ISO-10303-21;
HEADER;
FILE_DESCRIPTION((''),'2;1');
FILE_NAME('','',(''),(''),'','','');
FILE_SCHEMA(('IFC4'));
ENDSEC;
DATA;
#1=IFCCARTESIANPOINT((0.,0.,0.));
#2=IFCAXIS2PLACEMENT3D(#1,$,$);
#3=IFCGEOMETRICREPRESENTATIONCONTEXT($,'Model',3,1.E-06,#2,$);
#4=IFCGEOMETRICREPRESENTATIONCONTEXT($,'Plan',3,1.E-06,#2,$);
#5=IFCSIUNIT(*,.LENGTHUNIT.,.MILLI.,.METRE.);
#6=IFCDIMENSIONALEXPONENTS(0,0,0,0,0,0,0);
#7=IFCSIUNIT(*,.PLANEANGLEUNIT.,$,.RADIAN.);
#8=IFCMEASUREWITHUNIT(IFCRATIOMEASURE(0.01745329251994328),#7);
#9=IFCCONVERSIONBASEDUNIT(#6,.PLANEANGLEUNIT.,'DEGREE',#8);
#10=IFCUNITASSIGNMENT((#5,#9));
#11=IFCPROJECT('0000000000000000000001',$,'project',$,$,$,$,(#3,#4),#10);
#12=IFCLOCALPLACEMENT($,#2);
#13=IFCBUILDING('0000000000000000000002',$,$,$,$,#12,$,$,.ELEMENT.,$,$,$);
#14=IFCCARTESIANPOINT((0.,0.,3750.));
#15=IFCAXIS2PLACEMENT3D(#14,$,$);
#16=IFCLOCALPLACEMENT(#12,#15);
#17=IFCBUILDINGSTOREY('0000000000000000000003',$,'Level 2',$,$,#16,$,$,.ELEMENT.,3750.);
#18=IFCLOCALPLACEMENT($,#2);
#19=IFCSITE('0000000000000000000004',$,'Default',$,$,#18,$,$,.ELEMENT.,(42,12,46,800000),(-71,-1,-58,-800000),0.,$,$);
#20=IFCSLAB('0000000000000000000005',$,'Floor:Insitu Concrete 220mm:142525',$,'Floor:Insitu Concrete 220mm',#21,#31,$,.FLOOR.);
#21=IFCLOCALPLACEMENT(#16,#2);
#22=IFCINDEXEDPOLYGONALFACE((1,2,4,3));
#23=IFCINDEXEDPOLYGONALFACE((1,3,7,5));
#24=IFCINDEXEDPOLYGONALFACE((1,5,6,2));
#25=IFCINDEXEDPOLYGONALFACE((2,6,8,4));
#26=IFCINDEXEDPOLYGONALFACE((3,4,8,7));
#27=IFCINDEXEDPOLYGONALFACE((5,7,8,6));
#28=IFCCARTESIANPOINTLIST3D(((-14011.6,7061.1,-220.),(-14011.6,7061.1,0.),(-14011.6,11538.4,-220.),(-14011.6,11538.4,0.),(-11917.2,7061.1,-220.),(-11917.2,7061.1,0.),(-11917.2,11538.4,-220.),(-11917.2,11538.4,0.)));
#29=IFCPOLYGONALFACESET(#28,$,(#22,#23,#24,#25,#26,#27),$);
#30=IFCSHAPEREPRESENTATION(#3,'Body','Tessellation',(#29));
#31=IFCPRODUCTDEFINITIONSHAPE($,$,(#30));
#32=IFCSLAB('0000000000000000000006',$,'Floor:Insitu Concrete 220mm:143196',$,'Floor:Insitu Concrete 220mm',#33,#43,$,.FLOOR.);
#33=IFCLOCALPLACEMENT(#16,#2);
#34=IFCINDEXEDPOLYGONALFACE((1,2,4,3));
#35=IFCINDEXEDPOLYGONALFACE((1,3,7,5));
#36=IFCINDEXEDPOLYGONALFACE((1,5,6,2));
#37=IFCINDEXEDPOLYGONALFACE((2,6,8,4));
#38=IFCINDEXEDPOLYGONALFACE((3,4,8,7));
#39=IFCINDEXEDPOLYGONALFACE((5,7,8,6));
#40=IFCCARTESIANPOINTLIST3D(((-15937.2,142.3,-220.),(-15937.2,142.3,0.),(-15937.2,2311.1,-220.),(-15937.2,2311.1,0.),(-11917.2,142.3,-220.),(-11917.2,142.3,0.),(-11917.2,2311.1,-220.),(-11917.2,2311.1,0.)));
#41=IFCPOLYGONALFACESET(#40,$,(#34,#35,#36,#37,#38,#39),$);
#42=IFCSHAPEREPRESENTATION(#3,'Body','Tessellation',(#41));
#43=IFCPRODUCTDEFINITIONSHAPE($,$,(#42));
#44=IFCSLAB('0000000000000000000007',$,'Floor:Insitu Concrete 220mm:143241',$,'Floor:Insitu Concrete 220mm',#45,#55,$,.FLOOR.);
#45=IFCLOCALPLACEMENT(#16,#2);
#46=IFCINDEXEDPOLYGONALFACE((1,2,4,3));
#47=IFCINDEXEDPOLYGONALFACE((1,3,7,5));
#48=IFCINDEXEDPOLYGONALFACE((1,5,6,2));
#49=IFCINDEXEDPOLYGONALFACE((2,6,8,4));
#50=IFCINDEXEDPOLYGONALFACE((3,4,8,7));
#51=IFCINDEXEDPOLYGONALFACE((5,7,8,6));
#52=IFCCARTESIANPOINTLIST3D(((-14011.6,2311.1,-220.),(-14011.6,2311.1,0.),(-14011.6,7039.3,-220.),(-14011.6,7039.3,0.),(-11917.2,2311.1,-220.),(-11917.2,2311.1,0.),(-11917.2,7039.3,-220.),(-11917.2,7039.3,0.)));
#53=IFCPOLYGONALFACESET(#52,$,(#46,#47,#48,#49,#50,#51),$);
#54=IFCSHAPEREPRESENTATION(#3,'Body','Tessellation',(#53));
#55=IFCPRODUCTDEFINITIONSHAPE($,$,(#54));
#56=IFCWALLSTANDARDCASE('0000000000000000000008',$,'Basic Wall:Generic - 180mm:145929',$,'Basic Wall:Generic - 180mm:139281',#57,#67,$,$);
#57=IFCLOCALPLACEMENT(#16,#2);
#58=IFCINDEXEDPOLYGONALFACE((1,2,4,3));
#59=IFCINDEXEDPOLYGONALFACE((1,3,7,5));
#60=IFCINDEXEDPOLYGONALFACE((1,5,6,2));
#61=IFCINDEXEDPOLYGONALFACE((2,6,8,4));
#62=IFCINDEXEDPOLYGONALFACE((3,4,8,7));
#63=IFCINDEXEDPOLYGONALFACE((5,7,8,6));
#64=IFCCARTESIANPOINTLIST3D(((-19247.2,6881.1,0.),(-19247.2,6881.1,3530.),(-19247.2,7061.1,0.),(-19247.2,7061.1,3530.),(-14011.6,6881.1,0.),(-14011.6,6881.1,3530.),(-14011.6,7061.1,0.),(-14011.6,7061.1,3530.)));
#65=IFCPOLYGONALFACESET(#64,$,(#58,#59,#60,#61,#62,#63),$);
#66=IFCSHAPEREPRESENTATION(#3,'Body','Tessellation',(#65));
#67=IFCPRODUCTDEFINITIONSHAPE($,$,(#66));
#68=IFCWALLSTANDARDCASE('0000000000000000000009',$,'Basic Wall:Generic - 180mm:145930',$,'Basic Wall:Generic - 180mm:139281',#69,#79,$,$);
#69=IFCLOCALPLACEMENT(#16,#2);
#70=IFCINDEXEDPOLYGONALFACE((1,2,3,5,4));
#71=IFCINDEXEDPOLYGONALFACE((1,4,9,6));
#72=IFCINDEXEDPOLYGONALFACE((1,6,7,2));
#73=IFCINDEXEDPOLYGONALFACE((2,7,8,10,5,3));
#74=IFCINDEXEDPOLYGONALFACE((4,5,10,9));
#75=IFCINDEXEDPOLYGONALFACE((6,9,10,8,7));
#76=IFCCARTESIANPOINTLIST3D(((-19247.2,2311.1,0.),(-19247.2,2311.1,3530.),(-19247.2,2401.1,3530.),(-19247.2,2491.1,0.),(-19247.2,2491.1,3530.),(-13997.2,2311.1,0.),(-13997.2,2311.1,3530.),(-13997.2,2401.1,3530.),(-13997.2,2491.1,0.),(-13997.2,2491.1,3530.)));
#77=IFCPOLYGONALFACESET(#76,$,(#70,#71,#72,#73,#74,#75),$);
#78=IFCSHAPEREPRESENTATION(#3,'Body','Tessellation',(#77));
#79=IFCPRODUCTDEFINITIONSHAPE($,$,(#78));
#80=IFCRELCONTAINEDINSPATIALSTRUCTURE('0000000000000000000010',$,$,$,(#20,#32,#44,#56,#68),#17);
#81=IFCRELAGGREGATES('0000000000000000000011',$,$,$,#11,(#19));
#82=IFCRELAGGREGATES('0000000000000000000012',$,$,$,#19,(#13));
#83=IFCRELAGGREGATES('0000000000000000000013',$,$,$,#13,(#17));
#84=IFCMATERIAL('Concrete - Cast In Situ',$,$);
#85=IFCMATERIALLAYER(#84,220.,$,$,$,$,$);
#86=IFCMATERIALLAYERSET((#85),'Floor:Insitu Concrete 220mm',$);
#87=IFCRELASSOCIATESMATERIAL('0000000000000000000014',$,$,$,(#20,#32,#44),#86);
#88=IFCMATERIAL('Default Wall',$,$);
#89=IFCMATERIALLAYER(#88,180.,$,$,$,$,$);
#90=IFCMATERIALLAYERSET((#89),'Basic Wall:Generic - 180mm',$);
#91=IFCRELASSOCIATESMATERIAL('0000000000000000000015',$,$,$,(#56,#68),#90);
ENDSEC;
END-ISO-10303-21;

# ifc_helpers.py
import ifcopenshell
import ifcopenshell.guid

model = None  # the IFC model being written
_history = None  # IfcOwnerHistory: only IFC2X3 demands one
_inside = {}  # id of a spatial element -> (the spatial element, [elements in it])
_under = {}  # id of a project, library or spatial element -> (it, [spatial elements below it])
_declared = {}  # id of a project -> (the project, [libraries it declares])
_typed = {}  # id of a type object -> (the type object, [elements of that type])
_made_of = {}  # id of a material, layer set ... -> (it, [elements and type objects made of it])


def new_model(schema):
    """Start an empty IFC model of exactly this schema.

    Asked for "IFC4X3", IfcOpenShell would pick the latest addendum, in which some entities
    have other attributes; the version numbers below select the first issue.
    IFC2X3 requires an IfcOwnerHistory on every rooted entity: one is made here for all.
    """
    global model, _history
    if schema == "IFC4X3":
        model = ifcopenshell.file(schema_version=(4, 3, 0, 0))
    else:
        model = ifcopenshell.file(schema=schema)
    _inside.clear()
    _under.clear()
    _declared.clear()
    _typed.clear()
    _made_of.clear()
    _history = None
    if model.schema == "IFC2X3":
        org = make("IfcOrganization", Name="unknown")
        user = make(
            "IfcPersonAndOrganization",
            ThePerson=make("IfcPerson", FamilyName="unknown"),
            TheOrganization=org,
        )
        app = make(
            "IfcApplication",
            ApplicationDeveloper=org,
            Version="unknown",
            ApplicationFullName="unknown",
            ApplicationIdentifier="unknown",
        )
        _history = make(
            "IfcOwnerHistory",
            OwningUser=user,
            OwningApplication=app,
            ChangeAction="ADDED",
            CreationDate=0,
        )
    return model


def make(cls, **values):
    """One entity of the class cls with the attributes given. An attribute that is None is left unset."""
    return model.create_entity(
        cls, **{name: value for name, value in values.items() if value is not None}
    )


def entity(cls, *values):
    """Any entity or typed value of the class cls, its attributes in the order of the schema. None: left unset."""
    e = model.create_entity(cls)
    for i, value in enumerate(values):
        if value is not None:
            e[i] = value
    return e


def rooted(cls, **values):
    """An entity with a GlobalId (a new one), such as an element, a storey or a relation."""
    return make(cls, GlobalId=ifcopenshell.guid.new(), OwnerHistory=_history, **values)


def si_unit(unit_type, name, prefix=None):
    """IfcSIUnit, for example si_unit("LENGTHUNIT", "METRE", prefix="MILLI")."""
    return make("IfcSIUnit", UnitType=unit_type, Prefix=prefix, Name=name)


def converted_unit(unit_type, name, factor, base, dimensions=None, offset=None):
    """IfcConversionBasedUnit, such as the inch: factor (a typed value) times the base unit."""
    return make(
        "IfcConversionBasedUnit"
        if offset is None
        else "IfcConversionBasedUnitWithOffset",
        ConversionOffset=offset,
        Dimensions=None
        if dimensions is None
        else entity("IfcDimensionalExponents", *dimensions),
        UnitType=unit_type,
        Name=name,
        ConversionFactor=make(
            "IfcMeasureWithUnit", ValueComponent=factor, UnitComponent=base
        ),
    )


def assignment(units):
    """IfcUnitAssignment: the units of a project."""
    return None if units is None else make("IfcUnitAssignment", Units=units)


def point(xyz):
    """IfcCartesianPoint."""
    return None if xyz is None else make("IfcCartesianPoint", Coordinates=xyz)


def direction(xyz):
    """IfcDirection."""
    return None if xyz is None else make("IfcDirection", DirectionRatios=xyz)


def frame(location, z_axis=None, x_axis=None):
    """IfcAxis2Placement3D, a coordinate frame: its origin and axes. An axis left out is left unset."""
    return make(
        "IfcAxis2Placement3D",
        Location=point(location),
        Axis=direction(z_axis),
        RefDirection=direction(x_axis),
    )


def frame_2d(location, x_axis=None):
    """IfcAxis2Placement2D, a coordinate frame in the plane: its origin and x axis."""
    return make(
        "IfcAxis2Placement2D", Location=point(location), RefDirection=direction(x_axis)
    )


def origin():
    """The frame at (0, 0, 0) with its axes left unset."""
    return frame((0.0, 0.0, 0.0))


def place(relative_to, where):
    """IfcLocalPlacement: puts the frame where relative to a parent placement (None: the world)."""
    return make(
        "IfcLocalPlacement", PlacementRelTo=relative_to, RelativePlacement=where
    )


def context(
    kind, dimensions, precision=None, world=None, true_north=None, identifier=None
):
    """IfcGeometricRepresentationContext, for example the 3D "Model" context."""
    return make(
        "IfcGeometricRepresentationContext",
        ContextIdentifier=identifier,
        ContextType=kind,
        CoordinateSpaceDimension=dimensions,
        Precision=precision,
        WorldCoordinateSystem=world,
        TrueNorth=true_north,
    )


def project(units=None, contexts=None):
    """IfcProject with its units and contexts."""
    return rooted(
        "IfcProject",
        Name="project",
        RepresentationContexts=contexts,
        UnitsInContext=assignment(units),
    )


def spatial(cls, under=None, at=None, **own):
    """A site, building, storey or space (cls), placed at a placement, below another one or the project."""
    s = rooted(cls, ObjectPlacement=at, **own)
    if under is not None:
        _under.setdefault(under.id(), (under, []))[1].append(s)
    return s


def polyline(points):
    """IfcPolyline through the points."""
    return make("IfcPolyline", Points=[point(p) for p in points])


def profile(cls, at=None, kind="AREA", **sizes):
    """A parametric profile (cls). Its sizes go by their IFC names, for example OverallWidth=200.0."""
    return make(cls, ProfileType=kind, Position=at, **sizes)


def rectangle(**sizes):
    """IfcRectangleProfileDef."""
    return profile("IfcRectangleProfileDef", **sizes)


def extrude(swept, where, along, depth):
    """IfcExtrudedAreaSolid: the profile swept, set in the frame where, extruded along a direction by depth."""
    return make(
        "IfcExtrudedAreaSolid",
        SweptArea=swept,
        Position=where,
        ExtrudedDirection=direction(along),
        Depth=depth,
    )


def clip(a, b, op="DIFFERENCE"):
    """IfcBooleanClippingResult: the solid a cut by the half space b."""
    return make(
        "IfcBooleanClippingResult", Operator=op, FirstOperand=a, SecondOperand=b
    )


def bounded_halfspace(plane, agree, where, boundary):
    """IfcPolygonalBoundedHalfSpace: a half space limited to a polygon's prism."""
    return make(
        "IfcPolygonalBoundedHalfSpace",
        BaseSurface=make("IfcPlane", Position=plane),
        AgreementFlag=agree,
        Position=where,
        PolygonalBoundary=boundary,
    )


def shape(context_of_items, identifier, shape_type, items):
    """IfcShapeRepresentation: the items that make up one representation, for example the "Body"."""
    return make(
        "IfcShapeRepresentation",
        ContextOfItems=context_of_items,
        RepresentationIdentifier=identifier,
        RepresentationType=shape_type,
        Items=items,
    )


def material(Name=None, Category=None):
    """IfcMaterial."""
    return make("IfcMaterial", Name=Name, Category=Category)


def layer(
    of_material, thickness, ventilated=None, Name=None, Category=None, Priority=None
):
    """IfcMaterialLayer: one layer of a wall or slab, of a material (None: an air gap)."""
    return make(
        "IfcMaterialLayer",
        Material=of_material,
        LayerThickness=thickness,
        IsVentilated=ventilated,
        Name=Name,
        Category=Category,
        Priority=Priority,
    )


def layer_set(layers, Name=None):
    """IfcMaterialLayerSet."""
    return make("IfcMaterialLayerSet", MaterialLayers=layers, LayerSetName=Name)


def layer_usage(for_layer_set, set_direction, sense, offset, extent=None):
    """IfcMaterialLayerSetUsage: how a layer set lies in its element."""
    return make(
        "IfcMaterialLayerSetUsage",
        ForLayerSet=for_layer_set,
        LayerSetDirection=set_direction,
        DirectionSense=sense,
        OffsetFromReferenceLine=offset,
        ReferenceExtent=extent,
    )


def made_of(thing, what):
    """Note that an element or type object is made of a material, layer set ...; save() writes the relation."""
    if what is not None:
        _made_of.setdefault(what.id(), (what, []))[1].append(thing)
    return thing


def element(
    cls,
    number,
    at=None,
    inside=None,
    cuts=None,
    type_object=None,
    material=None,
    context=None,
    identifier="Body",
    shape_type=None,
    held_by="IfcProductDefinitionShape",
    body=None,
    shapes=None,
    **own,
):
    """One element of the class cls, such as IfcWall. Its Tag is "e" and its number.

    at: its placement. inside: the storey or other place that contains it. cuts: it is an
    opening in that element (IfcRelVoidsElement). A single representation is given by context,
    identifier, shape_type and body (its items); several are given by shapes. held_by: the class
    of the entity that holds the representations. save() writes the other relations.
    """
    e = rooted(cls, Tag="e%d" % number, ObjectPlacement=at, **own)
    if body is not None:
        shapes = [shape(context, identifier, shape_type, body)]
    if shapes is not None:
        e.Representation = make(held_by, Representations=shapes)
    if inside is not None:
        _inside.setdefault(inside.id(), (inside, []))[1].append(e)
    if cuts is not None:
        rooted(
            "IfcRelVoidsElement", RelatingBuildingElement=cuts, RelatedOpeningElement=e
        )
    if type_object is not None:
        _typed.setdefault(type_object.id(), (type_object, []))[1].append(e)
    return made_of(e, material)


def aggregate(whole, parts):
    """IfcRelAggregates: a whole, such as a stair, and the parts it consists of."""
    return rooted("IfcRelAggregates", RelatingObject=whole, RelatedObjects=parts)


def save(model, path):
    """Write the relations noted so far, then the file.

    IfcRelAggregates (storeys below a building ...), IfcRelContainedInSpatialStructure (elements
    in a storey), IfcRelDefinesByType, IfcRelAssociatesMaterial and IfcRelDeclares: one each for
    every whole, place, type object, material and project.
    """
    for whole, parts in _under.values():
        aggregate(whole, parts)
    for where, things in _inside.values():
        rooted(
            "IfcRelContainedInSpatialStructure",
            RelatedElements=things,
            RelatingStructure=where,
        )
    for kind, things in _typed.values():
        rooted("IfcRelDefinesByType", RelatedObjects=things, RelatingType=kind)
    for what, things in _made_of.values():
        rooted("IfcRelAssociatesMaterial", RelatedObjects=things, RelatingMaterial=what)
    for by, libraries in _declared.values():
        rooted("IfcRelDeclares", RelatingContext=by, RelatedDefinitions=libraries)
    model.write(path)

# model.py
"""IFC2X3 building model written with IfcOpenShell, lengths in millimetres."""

from ifc_helpers import new_model, entity, si_unit, converted_unit, frame, frame_2d, origin, place, context, project, spatial, polyline, rectangle, extrude, clip, bounded_halfspace, material, layer, layer_set, layer_usage, element, save


model = new_model("IFC2X3")

# Units and contexts
model_context = context("Model", 3, precision=1e-06, world=origin())
plan_context = context("Plan", 3, precision=1e-06, world=origin())
ifc_project = project(units=[si_unit("LENGTHUNIT", "METRE", prefix="MILLI"), converted_unit("PLANEANGLEUNIT", "DEGREE", entity("IfcRatioMeasure", 0.01745329251994328), si_unit("PLANEANGLEUNIT", "RADIAN"), dimensions=[0, 0, 0, 0, 0, 0, 0])], contexts=[model_context, plan_context])

# Site, building, storey
site_placement = place(None, origin())
site = spatial("IfcSite", under=ifc_project, at=site_placement, Name="Default", CompositionType="ELEMENT", RefLatitude=(42, 12, 46, 800000), RefLongitude=(-71, -1, -58, -800000), RefElevation=0.0)
building_placement = place(None, origin())
building = spatial("IfcBuilding", under=site, at=building_placement, CompositionType="ELEMENT")
storey_placement = place(building_placement, frame((0.0, 0.0, 3750.0)))
storey = spatial("IfcBuildingStorey", under=building, at=storey_placement, Name="Level 2", CompositionType="ELEMENT", Elevation=3750.0)

# Slabs
ifc_material_1 = material(Name="Concrete - Cast In Situ")
ifc_layer_1 = layer(ifc_material_1, 220.0)
ifc_layer_set_1 = layer_set([ifc_layer_1], Name="Floor:Insitu Concrete 220mm")
ifc_layer_usage_1 = layer_usage(ifc_layer_set_1, "AXIS3", "POSITIVE", 0.0)
slab_1_placement = place(storey_placement, frame((-14011.6, 7061.1, -220.0)))
element("IfcSlab", 1, at=slab_1_placement, inside=storey, material=ifc_layer_usage_1, Name="Floor:Insitu Concrete 220mm:142525", ObjectType="Floor:Insitu Concrete 220mm", PredefinedType="FLOOR", context=model_context, shape_type="SweptSolid", body=[
    extrude(rectangle(XDim=4477.3, YDim=2094.4, at=frame_2d((12964.4, 9299.7), x_axis=(0.0, -1.0))), frame((14011.6, -7061.1, 220.0), z_axis=(0.0, 0.0, -1.0), x_axis=(-1.0, 0.0, 0.0)), (0.0, 0.0, 1.0), 220.0),
])
ifc_layer_usage_2 = layer_usage(ifc_layer_set_1, "AXIS3", "POSITIVE", 0.0)
slab_2_placement = place(storey_placement, frame((-15937.2, 142.3, -220.0)))
element("IfcSlab", 2, at=slab_2_placement, inside=storey, material=ifc_layer_usage_2, Name="Floor:Insitu Concrete 220mm:143196", ObjectType="Floor:Insitu Concrete 220mm", PredefinedType="FLOOR", context=model_context, shape_type="SweptSolid", body=[
    extrude(rectangle(XDim=2168.8, YDim=4020.0, at=frame_2d((13927.2, 1226.7), x_axis=(0.0, -1.0))), frame((15937.2, -142.3, 220.0), z_axis=(0.0, 0.0, -1.0), x_axis=(-1.0, 0.0, 0.0)), (0.0, 0.0, 1.0), 220.0),
])
ifc_layer_usage_3 = layer_usage(ifc_layer_set_1, "AXIS3", "POSITIVE", 0.0)
slab_3_placement = place(storey_placement, frame((-14011.6, 2311.1, -220.0)))
element("IfcSlab", 3, at=slab_3_placement, inside=storey, material=ifc_layer_usage_3, Name="Floor:Insitu Concrete 220mm:143241", ObjectType="Floor:Insitu Concrete 220mm", PredefinedType="FLOOR", context=model_context, shape_type="SweptSolid", body=[
    extrude(rectangle(XDim=4728.2, YDim=2094.4, at=frame_2d((12964.4, 4675.2), x_axis=(0.0, -1.0))), frame((14011.6, -2311.1, 220.0), z_axis=(0.0, 0.0, -1.0), x_axis=(-1.0, 0.0, 0.0)), (0.0, 0.0, 1.0), 220.0),
])

# Walls
ifc_material_2 = material(Name="Default Wall")
ifc_layer_2 = layer(ifc_material_2, 180.0)
ifc_layer_set_2 = layer_set([ifc_layer_2], Name="Basic Wall:Generic - 180mm")
ifc_layer_usage_4 = layer_usage(ifc_layer_set_2, "AXIS2", "POSITIVE", -90.0)
wall_1_placement = place(storey_placement, frame((-19247.2, 6971.1, 0.0)))
element("IfcWallStandardCase", 4, at=wall_1_placement, inside=storey, material=ifc_layer_usage_4, Name="Basic Wall:Generic - 180mm:145929", ObjectType="Basic Wall:Generic - 180mm:139281", context=model_context, shape_type="Clipping", body=[
    clip(extrude(rectangle(XDim=5235.6, YDim=180.0, at=frame_2d((2617.8, 0.0), x_axis=(-1.0, 0.0))), origin(), (0.0, 0.0, 1.0), 3750.0), bounded_halfspace(frame((0.0, -90.0, 3530.0), z_axis=(0.0, 0.0, 1.0), x_axis=(0.0, 1.0, 0.0)), False, frame((0.0, -90.0, 3530.0)), polyline([(0.0, 0.0), (5235.6, 0.0), (5235.6, 90.0), (5235.6, 180.0), (0.0, 180.0), (0.0, 90.0), (0.0, 0.0)]))),
])
ifc_layer_usage_5 = layer_usage(ifc_layer_set_2, "AXIS2", "POSITIVE", -90.0)
wall_2_placement = place(storey_placement, frame((-13997.2, 2401.1, 0.0), z_axis=(0.0, 0.0, 1.0), x_axis=(-1.0, 0.0, 0.0)))
element("IfcWallStandardCase", 5, at=wall_2_placement, inside=storey, material=ifc_layer_usage_5, Name="Basic Wall:Generic - 180mm:145930", ObjectType="Basic Wall:Generic - 180mm:139281", context=model_context, shape_type="Clipping", body=[
    clip(clip(clip(extrude(rectangle(XDim=5250.0, YDim=180.0, at=frame_2d((2625.0, 0.0), x_axis=(-1.0, 0.0))), origin(), (0.0, 0.0, 1.0), 3750.0), bounded_halfspace(frame((0.0, -90.0, 3530.0), z_axis=(0.0, 0.0, -1.0), x_axis=(0.0, 1.0, 0.0)), True, frame((0.0, -90.0, 3530.0)), polyline([(0.0, 0.0), (5250.0, 0.0), (5250.0, 90.0), (0.0, 90.0), (0.0, 0.0)]))), bounded_halfspace(frame((0.0, -90.0, 3530.0), z_axis=(0.0, 0.0, -1.0), x_axis=(0.0, 1.0, 0.0)), True, frame((0.0, -90.0, 3530.0)), polyline([(0.0, 0.0), (5250.0, 0.0), (5250.0, 90.0), (0.0, 90.0), (0.0, 0.0)]))), bounded_halfspace(frame((5250.0, 0.0, 3530.0), z_axis=(0.0, 0.0, 1.0), x_axis=(0.0, 1.0, 0.0)), False, frame((5250.0, 0.0, 3530.0)), polyline([(0.0, 0.0), (0.0, 90.0), (-5250.0, 90.0), (-5250.0, 0.0), (0.0, 0.0)]))),
])

save(model, "model.ifc")
